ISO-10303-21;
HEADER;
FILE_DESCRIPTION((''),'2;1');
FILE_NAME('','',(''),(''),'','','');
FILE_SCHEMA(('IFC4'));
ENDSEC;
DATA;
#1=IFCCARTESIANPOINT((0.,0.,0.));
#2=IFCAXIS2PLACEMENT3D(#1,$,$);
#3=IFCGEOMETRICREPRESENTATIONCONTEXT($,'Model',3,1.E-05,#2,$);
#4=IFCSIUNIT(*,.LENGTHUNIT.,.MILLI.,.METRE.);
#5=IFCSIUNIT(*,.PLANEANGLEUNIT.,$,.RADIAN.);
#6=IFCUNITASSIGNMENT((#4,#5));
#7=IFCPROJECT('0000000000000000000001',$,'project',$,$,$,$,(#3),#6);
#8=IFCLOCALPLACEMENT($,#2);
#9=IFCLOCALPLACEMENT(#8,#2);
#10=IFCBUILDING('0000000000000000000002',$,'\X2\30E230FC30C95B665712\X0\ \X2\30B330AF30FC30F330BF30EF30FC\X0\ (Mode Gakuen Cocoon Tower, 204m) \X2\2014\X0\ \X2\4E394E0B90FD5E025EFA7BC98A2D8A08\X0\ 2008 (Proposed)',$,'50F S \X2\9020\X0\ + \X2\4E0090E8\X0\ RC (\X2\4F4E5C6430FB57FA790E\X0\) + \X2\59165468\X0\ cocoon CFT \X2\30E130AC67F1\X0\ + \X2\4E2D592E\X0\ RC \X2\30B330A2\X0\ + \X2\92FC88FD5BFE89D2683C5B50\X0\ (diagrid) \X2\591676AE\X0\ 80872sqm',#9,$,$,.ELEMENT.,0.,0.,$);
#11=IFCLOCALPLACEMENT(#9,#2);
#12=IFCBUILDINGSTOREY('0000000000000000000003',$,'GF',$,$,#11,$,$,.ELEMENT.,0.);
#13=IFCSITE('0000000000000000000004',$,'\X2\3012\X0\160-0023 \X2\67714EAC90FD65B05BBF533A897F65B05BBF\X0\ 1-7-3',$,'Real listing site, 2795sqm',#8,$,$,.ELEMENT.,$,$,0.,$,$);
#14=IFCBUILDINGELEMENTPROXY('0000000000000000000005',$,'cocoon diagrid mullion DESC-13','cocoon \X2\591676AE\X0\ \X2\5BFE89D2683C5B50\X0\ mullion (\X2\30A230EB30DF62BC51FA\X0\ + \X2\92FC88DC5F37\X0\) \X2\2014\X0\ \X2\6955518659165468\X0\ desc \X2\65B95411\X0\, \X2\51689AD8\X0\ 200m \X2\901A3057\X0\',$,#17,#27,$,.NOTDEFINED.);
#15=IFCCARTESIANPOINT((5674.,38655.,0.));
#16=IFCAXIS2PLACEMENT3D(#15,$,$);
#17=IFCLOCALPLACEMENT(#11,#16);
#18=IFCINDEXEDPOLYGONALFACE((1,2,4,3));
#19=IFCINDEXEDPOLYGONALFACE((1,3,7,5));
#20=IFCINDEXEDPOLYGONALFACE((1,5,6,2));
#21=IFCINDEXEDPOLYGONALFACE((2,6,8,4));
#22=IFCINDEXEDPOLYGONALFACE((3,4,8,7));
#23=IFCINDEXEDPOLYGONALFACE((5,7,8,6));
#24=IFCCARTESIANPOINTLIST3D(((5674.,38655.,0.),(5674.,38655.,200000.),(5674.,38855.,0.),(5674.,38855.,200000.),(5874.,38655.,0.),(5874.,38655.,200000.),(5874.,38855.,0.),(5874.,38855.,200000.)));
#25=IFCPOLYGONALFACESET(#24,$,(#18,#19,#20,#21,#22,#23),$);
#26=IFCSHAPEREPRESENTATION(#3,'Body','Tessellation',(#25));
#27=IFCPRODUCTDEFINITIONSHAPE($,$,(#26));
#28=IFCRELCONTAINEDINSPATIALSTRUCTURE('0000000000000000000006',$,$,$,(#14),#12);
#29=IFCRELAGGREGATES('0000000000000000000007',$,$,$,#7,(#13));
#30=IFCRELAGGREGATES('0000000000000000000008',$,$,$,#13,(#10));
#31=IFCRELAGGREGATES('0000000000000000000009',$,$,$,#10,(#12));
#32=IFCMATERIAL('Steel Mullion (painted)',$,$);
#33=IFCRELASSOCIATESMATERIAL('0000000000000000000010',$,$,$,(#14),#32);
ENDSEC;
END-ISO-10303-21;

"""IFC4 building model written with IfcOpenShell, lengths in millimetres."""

from ifc_helpers import new_model, si_unit, frame, frame_2d, origin, place, context, project, spatial, rectangle, extrude, material, element, save


model = new_model("IFC4")

# Units and contexts
model_context = context("Model", 3, precision=1e-05, world=origin())
ifc_project = project(units=[si_unit("LENGTHUNIT", "METRE", prefix="MILLI"), si_unit("PLANEANGLEUNIT", "RADIAN")], contexts=[model_context])

# Site, building, storey
site_placement = place(None, origin())
site = spatial("IfcSite", under=ifc_project, at=site_placement, Name="〒160-0023 東京都新宿区西新宿 1-7-3", ObjectType="Real listing site, 2795sqm", CompositionType="ELEMENT", RefElevation=0.0)
building_placement = place(site_placement, origin())
building = spatial("IfcBuilding", under=site, at=building_placement, Name="モード学園 コクーンタワー (Mode Gakuen Cocoon Tower, 204m) — 丹下都市建築設計 2008 (Proposed)", ObjectType="50F S 造 + 一部 RC (低層・基礎) + 外周 cocoon CFT メガ柱 + 中央 RC コア + 鋼製対角格子 (diagrid) 外皮 80872sqm", CompositionType="ELEMENT", ElevationOfRefHeight=0.0, ElevationOfTerrain=0.0)
storey_placement = place(building_placement, origin())
storey = spatial("IfcBuildingStorey", under=building, at=storey_placement, Name="GF", CompositionType="ELEMENT", Elevation=0.0)

# Building element proxy
ifc_material_1 = material(Name="Steel Mullion (painted)")
proxy_1_placement = place(storey_placement, frame((5674.0, 38655.0, 0.0)))
element("IfcBuildingElementProxy", 1, at=proxy_1_placement, inside=storey, material=ifc_material_1, Name="cocoon diagrid mullion DESC-13", Description="cocoon 外皮 対角格子 mullion (アルミ押出 + 鋼補強) — 楕円外周 desc 方向, 全高 200m 通し", PredefinedType="NOTDEFINED", context=model_context, shape_type="SweptSolid", body=[
    extrude(rectangle(XDim=200.0, YDim=200.0, at=frame_2d((100.0, 100.0))), frame((5674.0, 38655.0, 0.0)), (0.0, 0.0, 1.0), 200000.0),
])

save(model, "model.ifc")
